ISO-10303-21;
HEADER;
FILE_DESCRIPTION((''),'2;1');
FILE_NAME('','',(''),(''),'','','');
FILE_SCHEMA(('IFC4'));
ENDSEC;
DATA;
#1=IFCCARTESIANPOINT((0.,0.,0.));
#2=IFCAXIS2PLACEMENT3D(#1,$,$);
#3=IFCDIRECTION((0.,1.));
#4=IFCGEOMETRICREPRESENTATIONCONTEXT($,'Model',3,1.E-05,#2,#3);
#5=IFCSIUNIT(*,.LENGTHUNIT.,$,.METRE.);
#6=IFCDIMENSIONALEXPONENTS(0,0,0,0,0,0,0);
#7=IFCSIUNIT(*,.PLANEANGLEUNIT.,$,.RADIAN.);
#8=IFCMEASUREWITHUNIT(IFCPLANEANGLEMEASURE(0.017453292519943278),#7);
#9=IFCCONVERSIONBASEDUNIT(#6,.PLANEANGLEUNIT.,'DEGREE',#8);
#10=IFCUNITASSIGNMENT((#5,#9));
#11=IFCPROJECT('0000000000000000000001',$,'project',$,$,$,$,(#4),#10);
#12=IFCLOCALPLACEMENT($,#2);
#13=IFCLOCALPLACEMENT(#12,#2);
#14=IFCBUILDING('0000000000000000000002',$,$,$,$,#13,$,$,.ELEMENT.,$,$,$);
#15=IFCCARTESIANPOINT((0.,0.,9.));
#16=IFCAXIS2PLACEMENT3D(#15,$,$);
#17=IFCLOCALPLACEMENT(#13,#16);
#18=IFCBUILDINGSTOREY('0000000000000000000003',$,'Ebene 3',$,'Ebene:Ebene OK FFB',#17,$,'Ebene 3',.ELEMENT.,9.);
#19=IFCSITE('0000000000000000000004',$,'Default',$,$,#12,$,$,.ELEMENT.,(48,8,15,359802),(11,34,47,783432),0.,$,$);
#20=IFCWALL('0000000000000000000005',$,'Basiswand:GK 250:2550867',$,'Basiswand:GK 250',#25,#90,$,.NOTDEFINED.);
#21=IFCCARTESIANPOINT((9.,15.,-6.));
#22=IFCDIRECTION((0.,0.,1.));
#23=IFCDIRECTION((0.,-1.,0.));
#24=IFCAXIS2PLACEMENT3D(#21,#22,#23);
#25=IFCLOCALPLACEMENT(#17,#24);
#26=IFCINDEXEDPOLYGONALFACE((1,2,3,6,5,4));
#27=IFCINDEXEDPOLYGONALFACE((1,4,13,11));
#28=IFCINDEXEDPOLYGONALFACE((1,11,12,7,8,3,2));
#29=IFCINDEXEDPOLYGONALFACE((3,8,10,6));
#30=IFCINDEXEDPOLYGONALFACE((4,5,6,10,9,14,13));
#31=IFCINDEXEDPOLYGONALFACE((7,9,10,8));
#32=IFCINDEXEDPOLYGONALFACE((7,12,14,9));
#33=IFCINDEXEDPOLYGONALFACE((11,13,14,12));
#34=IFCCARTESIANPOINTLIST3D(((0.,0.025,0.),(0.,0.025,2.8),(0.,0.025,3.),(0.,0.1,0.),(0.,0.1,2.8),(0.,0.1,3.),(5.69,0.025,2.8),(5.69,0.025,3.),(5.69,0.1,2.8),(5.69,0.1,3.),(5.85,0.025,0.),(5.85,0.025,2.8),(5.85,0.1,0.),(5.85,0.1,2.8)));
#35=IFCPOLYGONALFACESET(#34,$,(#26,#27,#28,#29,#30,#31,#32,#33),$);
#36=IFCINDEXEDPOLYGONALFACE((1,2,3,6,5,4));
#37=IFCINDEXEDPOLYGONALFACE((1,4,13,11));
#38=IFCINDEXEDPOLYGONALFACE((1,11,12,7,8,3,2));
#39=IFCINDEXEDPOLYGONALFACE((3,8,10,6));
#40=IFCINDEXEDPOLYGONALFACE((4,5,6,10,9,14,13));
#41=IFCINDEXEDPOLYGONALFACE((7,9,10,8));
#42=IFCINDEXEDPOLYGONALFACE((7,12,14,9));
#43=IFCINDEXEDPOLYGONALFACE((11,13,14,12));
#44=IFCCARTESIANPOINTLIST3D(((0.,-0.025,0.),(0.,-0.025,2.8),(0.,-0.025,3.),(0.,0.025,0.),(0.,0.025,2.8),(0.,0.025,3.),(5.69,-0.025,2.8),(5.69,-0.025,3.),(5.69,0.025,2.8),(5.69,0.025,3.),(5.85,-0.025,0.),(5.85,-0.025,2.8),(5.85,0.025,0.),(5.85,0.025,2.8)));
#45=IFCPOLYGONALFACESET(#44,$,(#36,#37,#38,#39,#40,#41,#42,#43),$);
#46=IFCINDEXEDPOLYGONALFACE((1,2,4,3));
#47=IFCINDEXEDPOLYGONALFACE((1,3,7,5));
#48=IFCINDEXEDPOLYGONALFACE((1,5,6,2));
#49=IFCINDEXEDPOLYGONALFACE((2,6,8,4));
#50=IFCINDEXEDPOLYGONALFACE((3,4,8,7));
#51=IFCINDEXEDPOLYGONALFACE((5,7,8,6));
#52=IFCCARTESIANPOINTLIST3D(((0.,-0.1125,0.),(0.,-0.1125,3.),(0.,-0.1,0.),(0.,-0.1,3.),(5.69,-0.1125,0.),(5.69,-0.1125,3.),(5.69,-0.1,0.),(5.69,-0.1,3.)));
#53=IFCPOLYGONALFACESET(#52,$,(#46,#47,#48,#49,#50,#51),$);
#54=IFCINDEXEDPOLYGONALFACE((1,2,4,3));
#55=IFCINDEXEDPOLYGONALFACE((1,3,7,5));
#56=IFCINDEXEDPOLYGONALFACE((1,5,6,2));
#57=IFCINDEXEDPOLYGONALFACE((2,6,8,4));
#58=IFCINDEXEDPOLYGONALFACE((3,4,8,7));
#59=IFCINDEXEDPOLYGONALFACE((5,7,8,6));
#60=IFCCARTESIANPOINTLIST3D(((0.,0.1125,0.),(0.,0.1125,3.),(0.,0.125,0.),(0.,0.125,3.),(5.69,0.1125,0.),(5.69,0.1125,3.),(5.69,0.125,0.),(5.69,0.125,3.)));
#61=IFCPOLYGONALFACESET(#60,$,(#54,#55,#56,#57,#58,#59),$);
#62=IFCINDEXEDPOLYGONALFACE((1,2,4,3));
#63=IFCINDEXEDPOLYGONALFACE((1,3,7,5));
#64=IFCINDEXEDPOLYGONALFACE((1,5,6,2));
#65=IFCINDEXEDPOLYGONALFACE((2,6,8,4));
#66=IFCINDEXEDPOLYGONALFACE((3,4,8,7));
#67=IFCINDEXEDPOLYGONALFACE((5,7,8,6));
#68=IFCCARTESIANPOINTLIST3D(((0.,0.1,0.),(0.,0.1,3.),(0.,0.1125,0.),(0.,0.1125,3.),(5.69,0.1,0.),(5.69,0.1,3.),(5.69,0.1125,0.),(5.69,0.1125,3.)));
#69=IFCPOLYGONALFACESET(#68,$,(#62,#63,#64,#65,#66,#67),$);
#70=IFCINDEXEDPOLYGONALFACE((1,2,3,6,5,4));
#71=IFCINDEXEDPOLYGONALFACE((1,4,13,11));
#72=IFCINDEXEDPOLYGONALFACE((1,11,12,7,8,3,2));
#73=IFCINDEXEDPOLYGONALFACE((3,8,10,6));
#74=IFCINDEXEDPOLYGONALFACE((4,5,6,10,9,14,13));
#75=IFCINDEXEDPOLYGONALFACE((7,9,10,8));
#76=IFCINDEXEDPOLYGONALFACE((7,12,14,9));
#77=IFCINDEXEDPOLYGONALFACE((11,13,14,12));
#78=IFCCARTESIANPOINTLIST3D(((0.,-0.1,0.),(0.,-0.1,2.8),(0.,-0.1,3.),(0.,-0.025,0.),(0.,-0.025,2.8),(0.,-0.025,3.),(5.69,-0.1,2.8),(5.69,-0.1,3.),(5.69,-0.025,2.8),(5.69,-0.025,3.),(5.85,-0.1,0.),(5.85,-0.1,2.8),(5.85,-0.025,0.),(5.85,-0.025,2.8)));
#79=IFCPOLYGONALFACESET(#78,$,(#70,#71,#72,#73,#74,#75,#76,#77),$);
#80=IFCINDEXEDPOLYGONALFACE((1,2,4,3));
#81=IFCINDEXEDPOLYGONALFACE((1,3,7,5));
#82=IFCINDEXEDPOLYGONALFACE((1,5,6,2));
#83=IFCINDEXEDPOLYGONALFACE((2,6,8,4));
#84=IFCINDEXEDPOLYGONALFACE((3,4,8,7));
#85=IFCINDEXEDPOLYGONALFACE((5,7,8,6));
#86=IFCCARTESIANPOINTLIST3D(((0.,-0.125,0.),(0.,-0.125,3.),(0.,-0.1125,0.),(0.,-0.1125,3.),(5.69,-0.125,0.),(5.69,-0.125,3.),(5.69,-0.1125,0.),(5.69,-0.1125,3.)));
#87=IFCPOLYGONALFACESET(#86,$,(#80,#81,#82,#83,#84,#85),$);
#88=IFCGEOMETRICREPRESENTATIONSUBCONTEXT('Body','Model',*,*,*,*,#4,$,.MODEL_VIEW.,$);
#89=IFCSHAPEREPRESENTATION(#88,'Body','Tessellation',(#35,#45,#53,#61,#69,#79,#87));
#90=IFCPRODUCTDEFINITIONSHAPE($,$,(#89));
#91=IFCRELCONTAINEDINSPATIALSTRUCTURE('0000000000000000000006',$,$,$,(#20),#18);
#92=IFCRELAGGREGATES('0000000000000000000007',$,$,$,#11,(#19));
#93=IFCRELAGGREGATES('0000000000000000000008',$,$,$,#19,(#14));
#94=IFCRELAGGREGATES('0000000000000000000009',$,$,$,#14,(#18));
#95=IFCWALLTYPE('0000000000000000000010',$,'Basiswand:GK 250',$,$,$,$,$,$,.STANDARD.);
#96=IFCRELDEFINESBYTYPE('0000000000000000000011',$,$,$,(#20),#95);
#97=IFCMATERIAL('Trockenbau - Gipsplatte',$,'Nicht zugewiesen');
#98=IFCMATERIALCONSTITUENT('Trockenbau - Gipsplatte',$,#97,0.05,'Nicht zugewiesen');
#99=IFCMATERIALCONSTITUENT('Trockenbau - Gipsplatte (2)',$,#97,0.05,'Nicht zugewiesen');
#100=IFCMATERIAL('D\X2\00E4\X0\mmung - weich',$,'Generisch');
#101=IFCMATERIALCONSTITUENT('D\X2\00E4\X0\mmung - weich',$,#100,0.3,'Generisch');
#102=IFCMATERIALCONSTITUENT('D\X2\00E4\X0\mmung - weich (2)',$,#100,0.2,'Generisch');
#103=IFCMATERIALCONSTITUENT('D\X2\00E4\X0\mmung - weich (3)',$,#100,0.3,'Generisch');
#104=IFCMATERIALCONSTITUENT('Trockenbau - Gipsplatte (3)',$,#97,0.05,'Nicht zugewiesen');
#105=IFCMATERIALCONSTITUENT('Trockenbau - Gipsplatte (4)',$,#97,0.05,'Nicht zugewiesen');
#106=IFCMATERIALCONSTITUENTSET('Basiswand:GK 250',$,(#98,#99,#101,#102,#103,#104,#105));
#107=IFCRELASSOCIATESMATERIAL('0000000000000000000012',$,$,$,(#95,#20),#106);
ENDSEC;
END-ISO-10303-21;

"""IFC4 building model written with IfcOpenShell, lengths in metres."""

from ifc_helpers import new_model, entity, si_unit, converted_unit, direction, frame, origin, place, context, subcontext, project, spatial, indexed_curve, outline, extrude, material, constituent, constituent_set, type_object, element, save


model = new_model("IFC4")

# Units and contexts
model_context = context("Model", 3, precision=1e-05, world=origin(), true_north=direction((0.0, 1.0)))
body_context = subcontext(model_context, "Body", "Model", "MODEL_VIEW")
ifc_project = project(units=[si_unit("LENGTHUNIT", "METRE"), converted_unit("PLANEANGLEUNIT", "DEGREE", entity("IfcPlaneAngleMeasure", 0.017453292519943278), si_unit("PLANEANGLEUNIT", "RADIAN"), dimensions=[0, 0, 0, 0, 0, 0, 0])], contexts=[model_context])

# Site, building, storey
site_placement = place(None, origin())
site = spatial("IfcSite", under=ifc_project, at=site_placement, Name="Default", CompositionType="ELEMENT", RefLatitude=(48, 8, 15, 359802), RefLongitude=(11, 34, 47, 783432), RefElevation=0.0)
building_placement = place(site_placement, origin())
building = spatial("IfcBuilding", under=site, at=building_placement, CompositionType="ELEMENT")
storey_placement = place(building_placement, frame((0.0, 0.0, 9.0)))
storey = spatial("IfcBuildingStorey", under=building, at=storey_placement, Name="Ebene 3", ObjectType="Ebene:Ebene OK FFB", LongName="Ebene 3", CompositionType="ELEMENT", Elevation=9.0)

# Wall
ifc_material_1 = material(Name="Trockenbau - Gipsplatte", Category="Nicht zugewiesen")
ifc_constituent_1 = constituent(ifc_material_1, Name="Trockenbau - Gipsplatte", Category="Nicht zugewiesen", fraction=0.05)
ifc_constituent_2 = constituent(ifc_material_1, Name="Trockenbau - Gipsplatte (2)", Category="Nicht zugewiesen", fraction=0.05)
ifc_material_2 = material(Name="Dämmung - weich", Category="Generisch")
ifc_constituent_3 = constituent(ifc_material_2, Name="Dämmung - weich", Category="Generisch", fraction=0.3)
ifc_constituent_4 = constituent(ifc_material_2, Name="Dämmung - weich (2)", Category="Generisch", fraction=0.2)
ifc_constituent_5 = constituent(ifc_material_2, Name="Dämmung - weich (3)", Category="Generisch", fraction=0.3)
ifc_constituent_6 = constituent(ifc_material_1, Name="Trockenbau - Gipsplatte (3)", Category="Nicht zugewiesen", fraction=0.05)
ifc_constituent_7 = constituent(ifc_material_1, Name="Trockenbau - Gipsplatte (4)", Category="Nicht zugewiesen", fraction=0.05)
ifc_constituent_set_1 = constituent_set(constituents=[ifc_constituent_1, ifc_constituent_2, ifc_constituent_3, ifc_constituent_4, ifc_constituent_5, ifc_constituent_6, ifc_constituent_7], Name="Basiswand:GK 250")
wall_type_1 = type_object("IfcWallType", Name="Basiswand:GK 250", PredefinedType="STANDARD", material=ifc_constituent_set_1)
wall_1_placement = place(storey_placement, frame((9.0, 15.0, -6.0), z_axis=(0.0, 0.0, 1.0), x_axis=(0.0, -1.0, 0.0)))
element("IfcWall", 1, at=wall_1_placement, inside=storey, type_object=wall_type_1, material=ifc_constituent_set_1, Name="Basiswand:GK 250:2550867", ObjectType="Basiswand:GK 250", PredefinedType="NOTDEFINED", context=body_context, shape_type="SweptSolid", body=[
    extrude(outline(indexed_curve([(-2.0571, -3.2971), (0.7429, -3.2971), (0.9429, -3.2971), (0.9429, 2.3929), (0.7429, 2.3929), (0.7429, 2.5529), (-2.0571, 2.5529), (-2.0571, -3.2971)], self_intersect=False)), frame((3.2971, 0.025, 2.0571), z_axis=(0.0, 1.0, 0.0), x_axis=(0.0, 0.0, 1.0)), (0.0, 0.0, 1.0), 0.075),
    extrude(outline(indexed_curve([(-2.0571, -3.2971), (0.7429, -3.2971), (0.9429, -3.2971), (0.9429, 2.3929), (0.7429, 2.3929), (0.7429, 2.5529), (-2.0571, 2.5529), (-2.0571, -3.2971)], self_intersect=False)), frame((3.2971, -0.025, 2.0571), z_axis=(0.0, 1.0, 0.0), x_axis=(0.0, 0.0, 1.0)), (0.0, 0.0, 1.0), 0.05),
    extrude(outline(indexed_curve([(-0.0063, -2.845), (0.0062, -2.845), (0.0063, 2.845), (-0.0062, 2.845), (-0.0063, -2.845)], self_intersect=False)), frame((2.845, -0.1063, 0.0), z_axis=(0.0, 0.0, 1.0), x_axis=(0.0, -1.0, 0.0)), (0.0, 0.0, 1.0), 3.0),
    extrude(outline(indexed_curve([(-0.0063, -2.845), (0.0062, -2.845), (0.0063, 2.845), (-0.0062, 2.845), (-0.0063, -2.845)], self_intersect=False)), frame((2.845, 0.1188, 0.0), z_axis=(0.0, 0.0, 1.0), x_axis=(0.0, -1.0, 0.0)), (0.0, 0.0, 1.0), 3.0),
    extrude(outline(indexed_curve([(-0.0063, -2.845), (0.0062, -2.845), (0.0063, 2.845), (-0.0062, 2.845), (-0.0063, -2.845)], self_intersect=False)), frame((2.845, 0.1062, 0.0), z_axis=(0.0, 0.0, 1.0), x_axis=(0.0, -1.0, 0.0)), (0.0, 0.0, 1.0), 3.0),
    extrude(outline(indexed_curve([(-2.0571, -3.2971), (0.7429, -3.2971), (0.9429, -3.2971), (0.9429, 2.3929), (0.7429, 2.3929), (0.7429, 2.5529), (-2.0571, 2.5529), (-2.0571, -3.2971)], self_intersect=False)), frame((3.2971, -0.1, 2.0571), z_axis=(0.0, 1.0, 0.0), x_axis=(0.0, 0.0, 1.0)), (0.0, 0.0, 1.0), 0.075),
    extrude(outline(indexed_curve([(-0.0063, -2.845), (0.0062, -2.845), (0.0063, 2.845), (-0.0062, 2.845), (-0.0063, -2.845)], self_intersect=False)), frame((2.845, -0.1188, 0.0), z_axis=(0.0, 0.0, 1.0), x_axis=(0.0, -1.0, 0.0)), (0.0, 0.0, 1.0), 3.0),
])

save(model, "model.ifc")
